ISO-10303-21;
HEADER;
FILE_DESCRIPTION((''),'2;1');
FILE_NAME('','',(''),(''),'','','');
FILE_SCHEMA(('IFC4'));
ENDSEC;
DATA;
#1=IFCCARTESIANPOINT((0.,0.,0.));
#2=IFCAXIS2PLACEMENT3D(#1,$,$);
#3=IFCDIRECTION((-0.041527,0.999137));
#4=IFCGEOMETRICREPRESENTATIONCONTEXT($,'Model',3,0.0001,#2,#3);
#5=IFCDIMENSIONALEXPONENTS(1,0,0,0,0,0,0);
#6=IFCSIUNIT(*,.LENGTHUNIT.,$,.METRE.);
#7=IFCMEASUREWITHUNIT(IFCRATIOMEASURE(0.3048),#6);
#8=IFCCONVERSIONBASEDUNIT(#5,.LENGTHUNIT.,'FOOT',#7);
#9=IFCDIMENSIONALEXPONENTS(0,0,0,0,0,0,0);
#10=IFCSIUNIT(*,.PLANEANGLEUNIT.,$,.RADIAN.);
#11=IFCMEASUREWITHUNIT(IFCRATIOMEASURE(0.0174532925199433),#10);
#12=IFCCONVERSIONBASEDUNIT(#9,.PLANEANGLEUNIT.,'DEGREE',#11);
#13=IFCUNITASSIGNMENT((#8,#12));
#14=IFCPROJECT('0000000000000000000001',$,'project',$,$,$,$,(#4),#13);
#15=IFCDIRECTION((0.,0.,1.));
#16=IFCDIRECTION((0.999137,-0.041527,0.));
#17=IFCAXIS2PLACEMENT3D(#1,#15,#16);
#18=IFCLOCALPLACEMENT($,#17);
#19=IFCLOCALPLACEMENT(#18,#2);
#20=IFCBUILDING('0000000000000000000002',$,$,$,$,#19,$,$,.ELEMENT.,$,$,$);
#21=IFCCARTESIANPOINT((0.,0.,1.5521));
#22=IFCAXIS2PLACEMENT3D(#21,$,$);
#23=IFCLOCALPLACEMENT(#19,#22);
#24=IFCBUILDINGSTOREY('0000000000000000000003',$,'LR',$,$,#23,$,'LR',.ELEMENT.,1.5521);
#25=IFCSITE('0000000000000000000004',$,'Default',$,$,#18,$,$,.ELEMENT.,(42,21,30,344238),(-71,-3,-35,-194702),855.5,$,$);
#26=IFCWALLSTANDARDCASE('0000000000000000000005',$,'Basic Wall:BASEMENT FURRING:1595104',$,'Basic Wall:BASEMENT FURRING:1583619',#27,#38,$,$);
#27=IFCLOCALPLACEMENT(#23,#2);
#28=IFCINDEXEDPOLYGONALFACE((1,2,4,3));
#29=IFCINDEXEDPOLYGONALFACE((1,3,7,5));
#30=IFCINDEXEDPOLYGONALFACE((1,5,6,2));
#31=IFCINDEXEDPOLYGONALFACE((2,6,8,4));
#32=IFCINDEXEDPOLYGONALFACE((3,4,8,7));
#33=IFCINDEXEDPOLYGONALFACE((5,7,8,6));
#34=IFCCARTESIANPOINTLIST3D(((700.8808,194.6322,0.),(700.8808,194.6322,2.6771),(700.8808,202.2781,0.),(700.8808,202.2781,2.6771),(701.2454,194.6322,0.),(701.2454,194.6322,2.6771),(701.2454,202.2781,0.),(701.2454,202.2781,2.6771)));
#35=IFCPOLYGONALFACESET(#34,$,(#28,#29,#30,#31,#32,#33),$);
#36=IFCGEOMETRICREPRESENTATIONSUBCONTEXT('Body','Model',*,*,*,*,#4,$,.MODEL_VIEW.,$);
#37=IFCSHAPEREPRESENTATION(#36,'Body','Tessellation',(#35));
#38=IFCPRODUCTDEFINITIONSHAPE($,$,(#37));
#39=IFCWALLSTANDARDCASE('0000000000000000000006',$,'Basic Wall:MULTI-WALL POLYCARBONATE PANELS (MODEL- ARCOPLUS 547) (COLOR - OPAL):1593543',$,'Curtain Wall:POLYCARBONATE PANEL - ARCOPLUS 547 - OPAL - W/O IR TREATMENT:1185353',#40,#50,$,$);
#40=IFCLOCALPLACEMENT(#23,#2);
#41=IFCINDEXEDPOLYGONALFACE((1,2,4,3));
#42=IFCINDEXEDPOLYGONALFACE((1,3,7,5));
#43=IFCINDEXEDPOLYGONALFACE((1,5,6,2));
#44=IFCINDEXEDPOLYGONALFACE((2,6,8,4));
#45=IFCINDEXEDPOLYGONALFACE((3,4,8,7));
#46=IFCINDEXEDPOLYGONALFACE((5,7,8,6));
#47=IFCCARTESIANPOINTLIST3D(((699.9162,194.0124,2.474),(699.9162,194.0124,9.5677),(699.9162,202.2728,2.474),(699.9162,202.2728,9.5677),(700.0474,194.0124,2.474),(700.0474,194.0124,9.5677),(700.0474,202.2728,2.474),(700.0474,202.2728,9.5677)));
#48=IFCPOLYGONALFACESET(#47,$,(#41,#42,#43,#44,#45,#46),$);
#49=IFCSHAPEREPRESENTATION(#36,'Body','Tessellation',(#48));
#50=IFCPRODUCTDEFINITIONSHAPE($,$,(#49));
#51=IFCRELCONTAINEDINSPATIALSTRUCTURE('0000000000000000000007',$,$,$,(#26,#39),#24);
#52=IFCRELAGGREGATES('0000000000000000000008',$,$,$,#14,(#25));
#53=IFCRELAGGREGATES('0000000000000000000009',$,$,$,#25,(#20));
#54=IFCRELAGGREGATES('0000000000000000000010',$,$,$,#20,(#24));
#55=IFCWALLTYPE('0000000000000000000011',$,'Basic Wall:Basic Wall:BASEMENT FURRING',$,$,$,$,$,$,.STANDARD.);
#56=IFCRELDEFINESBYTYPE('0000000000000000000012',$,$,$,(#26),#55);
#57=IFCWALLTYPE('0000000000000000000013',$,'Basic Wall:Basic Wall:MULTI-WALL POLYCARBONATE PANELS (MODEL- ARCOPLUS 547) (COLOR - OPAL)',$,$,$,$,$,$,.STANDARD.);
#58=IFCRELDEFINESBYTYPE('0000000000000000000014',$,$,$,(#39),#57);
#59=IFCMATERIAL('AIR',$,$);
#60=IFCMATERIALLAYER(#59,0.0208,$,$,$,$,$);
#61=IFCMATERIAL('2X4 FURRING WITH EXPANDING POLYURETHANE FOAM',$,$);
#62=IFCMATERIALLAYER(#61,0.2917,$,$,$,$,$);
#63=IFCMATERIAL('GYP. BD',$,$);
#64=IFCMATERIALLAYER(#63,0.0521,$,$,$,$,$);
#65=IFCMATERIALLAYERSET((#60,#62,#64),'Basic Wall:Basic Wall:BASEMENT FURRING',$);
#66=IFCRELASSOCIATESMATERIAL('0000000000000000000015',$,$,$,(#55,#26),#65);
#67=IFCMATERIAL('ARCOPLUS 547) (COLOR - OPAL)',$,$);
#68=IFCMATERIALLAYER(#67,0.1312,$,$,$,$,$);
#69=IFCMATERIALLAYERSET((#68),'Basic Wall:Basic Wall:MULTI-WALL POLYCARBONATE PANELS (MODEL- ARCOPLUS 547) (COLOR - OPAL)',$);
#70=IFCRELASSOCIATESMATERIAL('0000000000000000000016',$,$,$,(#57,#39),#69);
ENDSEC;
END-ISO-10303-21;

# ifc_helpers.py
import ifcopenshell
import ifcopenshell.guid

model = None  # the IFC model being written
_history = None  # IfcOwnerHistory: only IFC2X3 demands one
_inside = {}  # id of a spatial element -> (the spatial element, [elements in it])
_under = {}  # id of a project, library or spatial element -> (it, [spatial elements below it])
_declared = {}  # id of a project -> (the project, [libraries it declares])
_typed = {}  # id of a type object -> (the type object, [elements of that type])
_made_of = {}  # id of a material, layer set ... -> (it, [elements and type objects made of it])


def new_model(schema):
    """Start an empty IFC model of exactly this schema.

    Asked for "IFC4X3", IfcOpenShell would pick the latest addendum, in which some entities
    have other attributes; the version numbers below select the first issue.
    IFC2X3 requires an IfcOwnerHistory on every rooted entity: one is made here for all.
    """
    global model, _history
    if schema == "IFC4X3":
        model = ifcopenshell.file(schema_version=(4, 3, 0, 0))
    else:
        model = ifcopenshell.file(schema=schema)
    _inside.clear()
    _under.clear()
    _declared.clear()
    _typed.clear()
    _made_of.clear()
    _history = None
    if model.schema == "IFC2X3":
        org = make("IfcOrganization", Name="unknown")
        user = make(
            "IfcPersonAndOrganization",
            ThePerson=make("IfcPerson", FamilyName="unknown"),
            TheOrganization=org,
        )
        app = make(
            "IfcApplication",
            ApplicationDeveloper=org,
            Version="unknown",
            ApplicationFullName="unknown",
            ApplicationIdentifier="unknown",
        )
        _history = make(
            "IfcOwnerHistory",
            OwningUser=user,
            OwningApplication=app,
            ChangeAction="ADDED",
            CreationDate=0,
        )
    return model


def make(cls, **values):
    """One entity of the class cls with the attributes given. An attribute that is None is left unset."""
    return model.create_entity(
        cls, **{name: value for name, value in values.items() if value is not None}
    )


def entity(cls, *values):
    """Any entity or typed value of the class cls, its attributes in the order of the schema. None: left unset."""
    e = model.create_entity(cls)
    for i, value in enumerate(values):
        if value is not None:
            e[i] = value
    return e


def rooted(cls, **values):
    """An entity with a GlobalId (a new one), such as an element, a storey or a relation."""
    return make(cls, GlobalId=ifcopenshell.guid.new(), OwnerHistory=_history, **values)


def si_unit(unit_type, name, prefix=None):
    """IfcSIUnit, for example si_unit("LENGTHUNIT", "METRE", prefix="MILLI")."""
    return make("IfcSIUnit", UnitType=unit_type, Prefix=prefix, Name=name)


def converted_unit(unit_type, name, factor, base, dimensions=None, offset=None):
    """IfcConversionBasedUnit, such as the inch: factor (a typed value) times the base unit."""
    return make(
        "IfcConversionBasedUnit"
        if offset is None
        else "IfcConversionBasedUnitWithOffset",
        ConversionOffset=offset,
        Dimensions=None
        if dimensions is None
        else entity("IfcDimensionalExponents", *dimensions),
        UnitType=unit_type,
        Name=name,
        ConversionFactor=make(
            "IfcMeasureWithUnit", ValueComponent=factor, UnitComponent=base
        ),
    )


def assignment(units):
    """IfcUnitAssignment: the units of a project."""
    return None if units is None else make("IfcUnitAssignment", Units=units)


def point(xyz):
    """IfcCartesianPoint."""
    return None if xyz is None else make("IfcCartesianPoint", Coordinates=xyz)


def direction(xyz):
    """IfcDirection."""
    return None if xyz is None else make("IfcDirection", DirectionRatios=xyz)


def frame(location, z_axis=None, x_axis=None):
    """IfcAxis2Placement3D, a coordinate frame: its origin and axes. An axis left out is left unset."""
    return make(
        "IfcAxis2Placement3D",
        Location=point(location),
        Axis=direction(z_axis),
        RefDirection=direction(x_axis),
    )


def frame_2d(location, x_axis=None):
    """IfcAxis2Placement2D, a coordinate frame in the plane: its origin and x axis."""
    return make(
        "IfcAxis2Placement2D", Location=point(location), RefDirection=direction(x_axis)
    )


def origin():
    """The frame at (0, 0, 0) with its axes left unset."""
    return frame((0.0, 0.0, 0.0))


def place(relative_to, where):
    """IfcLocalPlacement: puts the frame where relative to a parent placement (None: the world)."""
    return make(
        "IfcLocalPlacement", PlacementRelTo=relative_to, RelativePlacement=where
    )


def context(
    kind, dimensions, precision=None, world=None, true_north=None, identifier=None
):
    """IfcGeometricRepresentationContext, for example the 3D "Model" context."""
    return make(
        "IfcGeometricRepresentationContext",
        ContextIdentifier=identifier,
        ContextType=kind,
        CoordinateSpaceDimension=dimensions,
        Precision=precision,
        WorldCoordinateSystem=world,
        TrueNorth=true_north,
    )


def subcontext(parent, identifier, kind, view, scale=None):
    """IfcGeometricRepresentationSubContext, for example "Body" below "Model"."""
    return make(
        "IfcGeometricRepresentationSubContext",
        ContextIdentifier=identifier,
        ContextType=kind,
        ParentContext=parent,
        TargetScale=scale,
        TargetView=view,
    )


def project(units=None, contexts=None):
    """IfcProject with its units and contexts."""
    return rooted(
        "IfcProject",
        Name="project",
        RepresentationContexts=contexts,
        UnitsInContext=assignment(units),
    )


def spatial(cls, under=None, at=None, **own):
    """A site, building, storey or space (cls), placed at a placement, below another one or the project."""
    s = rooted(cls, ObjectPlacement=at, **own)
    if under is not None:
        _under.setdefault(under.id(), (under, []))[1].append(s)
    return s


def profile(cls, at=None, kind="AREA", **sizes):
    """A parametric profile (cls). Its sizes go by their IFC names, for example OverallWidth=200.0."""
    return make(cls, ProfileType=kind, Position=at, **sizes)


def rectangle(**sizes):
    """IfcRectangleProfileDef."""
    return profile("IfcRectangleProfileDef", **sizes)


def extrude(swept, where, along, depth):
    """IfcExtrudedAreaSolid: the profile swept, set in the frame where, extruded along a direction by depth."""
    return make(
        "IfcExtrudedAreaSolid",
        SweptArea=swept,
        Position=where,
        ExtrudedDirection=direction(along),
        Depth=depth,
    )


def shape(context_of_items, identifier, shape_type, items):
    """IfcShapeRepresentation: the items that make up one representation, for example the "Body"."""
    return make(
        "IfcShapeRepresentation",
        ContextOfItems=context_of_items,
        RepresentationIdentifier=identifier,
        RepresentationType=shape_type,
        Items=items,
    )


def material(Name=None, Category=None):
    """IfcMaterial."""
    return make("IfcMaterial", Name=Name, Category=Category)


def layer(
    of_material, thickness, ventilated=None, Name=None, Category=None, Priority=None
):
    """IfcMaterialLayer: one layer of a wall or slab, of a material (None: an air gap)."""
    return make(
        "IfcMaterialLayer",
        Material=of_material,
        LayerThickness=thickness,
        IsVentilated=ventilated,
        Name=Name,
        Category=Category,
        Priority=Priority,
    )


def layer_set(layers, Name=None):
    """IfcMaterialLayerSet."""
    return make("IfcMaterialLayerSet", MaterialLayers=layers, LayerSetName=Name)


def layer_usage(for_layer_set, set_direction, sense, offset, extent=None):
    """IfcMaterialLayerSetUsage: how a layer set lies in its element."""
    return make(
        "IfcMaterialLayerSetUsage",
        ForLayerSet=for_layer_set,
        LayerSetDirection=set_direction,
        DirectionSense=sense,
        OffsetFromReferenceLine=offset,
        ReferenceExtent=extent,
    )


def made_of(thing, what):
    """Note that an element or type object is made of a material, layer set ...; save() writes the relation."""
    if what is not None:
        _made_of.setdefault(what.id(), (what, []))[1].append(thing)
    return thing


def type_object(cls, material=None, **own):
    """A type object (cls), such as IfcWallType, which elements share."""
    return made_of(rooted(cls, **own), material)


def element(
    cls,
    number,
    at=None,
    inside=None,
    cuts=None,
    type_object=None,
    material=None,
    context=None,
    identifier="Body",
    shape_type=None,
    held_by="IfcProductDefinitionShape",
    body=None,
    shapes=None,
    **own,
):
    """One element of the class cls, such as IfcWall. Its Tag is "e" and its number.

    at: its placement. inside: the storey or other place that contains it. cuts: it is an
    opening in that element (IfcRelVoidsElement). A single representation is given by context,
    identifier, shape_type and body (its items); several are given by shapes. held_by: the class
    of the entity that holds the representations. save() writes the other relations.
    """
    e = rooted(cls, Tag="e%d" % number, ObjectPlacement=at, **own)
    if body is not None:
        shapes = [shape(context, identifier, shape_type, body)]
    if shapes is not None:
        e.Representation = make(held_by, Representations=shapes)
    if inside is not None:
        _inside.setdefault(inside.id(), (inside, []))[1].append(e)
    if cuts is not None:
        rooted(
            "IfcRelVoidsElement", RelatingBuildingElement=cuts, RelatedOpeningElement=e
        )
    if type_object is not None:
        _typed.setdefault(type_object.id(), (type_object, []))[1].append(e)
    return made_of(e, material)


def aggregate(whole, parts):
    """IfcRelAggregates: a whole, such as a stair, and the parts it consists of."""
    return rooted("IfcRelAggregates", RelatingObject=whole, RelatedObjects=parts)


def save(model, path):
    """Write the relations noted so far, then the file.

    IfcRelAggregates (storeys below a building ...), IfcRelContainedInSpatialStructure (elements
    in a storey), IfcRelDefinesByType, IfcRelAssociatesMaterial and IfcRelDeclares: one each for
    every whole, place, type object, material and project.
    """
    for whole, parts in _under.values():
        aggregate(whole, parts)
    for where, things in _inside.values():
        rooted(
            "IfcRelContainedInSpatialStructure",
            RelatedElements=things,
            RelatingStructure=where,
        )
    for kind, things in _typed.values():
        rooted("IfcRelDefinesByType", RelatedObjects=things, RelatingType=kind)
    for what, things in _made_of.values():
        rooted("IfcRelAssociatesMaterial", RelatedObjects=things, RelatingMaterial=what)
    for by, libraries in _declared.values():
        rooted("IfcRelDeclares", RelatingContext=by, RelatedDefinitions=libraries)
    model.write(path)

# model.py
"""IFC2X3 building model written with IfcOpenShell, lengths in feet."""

from ifc_helpers import new_model, entity, si_unit, converted_unit, direction, frame, frame_2d, origin, place, context, subcontext, project, spatial, rectangle, extrude, material, layer, layer_set, layer_usage, type_object, element, save


model = new_model("IFC2X3")

# Units and contexts
model_context = context("Model", 3, precision=0.0001, world=origin(), true_north=direction((-0.041527, 0.999137)))
body_context = subcontext(model_context, "Body", "Model", "MODEL_VIEW")
ifc_project = project(units=[converted_unit("LENGTHUNIT", "FOOT", entity("IfcRatioMeasure", 0.3048), si_unit("LENGTHUNIT", "METRE"), dimensions=[1, 0, 0, 0, 0, 0, 0]), converted_unit("PLANEANGLEUNIT", "DEGREE", entity("IfcRatioMeasure", 0.0174532925199433), si_unit("PLANEANGLEUNIT", "RADIAN"), dimensions=[0, 0, 0, 0, 0, 0, 0])], contexts=[model_context])

# Site, building, storey
site_placement = place(None, frame((0.0, 0.0, 0.0), z_axis=(0.0, 0.0, 1.0), x_axis=(0.999137, -0.041527, 0.0)))
site = spatial("IfcSite", under=ifc_project, at=site_placement, Name="Default", CompositionType="ELEMENT", RefLatitude=(42, 21, 30, 344238), RefLongitude=(-71, -3, -35, -194702), RefElevation=855.5)
building_placement = place(site_placement, origin())
building = spatial("IfcBuilding", under=site, at=building_placement, CompositionType="ELEMENT")
storey_placement = place(building_placement, frame((0.0, 0.0, 1.5521)))
storey = spatial("IfcBuildingStorey", under=building, at=storey_placement, Name="LR", LongName="LR", CompositionType="ELEMENT", Elevation=1.5521)

# Walls
ifc_material_1 = material(Name="AIR")
ifc_layer_1 = layer(ifc_material_1, 0.0208)
ifc_material_2 = material(Name="2X4 FURRING WITH EXPANDING POLYURETHANE FOAM")
ifc_layer_2 = layer(ifc_material_2, 0.2917)
ifc_material_3 = material(Name="GYP. BD")
ifc_layer_3 = layer(ifc_material_3, 0.0521)
ifc_layer_set_1 = layer_set([ifc_layer_1, ifc_layer_2, ifc_layer_3], Name="Basic Wall:Basic Wall:BASEMENT FURRING")
ifc_layer_usage_1 = layer_usage(ifc_layer_set_1, "AXIS2", "NEGATIVE", 0.1823)
wall_type_1 = type_object("IfcWallType", Name="Basic Wall:Basic Wall:BASEMENT FURRING", PredefinedType="STANDARD", material=ifc_layer_set_1)
wall_1_placement = place(storey_placement, frame((701.0631, 194.6322, 0.0), z_axis=(0.0, 0.0, 1.0), x_axis=(0.0, 1.0, 0.0)))
element("IfcWallStandardCase", 1, at=wall_1_placement, inside=storey, type_object=wall_type_1, material=ifc_layer_usage_1, Name="Basic Wall:BASEMENT FURRING:1595104", ObjectType="Basic Wall:BASEMENT FURRING:1583619", context=body_context, shape_type="SweptSolid", body=[
    extrude(rectangle(XDim=7.6458, YDim=0.3646, at=frame_2d((3.8229, 0.0), x_axis=(-1.0, 0.0))), origin(), (0.0, 0.0, 1.0), 2.6771),
])
ifc_material_4 = material(Name="ARCOPLUS 547) (COLOR - OPAL)")
ifc_layer_4 = layer(ifc_material_4, 0.1312)
ifc_layer_set_2 = layer_set([ifc_layer_4], Name="Basic Wall:Basic Wall:MULTI-WALL POLYCARBONATE PANELS (MODEL- ARCOPLUS 547) (COLOR - OPAL)")
ifc_layer_usage_2 = layer_usage(ifc_layer_set_2, "AXIS2", "NEGATIVE", 0.0656)
wall_type_2 = type_object("IfcWallType", Name="Basic Wall:Basic Wall:MULTI-WALL POLYCARBONATE PANELS (MODEL- ARCOPLUS 547) (COLOR - OPAL)", PredefinedType="STANDARD", material=ifc_layer_set_2)
wall_2_placement = place(storey_placement, frame((699.9818, 194.0124, 2.474), z_axis=(0.0, 0.0, 1.0), x_axis=(0.0, 1.0, 0.0)))
element("IfcWallStandardCase", 2, at=wall_2_placement, inside=storey, type_object=wall_type_2, material=ifc_layer_usage_2, Name="Basic Wall:MULTI-WALL POLYCARBONATE PANELS (MODEL- ARCOPLUS 547) (COLOR - OPAL):1593543", ObjectType="Curtain Wall:POLYCARBONATE PANEL - ARCOPLUS 547 - OPAL - W/O IR TREATMENT:1185353", context=body_context, shape_type="SweptSolid", body=[
    extrude(rectangle(XDim=8.2604, YDim=0.1312, at=frame_2d((4.1302, 0.0), x_axis=(-1.0, 0.0))), origin(), (0.0, 0.0, 1.0), 7.0937),
])

save(model, "model.ifc")
